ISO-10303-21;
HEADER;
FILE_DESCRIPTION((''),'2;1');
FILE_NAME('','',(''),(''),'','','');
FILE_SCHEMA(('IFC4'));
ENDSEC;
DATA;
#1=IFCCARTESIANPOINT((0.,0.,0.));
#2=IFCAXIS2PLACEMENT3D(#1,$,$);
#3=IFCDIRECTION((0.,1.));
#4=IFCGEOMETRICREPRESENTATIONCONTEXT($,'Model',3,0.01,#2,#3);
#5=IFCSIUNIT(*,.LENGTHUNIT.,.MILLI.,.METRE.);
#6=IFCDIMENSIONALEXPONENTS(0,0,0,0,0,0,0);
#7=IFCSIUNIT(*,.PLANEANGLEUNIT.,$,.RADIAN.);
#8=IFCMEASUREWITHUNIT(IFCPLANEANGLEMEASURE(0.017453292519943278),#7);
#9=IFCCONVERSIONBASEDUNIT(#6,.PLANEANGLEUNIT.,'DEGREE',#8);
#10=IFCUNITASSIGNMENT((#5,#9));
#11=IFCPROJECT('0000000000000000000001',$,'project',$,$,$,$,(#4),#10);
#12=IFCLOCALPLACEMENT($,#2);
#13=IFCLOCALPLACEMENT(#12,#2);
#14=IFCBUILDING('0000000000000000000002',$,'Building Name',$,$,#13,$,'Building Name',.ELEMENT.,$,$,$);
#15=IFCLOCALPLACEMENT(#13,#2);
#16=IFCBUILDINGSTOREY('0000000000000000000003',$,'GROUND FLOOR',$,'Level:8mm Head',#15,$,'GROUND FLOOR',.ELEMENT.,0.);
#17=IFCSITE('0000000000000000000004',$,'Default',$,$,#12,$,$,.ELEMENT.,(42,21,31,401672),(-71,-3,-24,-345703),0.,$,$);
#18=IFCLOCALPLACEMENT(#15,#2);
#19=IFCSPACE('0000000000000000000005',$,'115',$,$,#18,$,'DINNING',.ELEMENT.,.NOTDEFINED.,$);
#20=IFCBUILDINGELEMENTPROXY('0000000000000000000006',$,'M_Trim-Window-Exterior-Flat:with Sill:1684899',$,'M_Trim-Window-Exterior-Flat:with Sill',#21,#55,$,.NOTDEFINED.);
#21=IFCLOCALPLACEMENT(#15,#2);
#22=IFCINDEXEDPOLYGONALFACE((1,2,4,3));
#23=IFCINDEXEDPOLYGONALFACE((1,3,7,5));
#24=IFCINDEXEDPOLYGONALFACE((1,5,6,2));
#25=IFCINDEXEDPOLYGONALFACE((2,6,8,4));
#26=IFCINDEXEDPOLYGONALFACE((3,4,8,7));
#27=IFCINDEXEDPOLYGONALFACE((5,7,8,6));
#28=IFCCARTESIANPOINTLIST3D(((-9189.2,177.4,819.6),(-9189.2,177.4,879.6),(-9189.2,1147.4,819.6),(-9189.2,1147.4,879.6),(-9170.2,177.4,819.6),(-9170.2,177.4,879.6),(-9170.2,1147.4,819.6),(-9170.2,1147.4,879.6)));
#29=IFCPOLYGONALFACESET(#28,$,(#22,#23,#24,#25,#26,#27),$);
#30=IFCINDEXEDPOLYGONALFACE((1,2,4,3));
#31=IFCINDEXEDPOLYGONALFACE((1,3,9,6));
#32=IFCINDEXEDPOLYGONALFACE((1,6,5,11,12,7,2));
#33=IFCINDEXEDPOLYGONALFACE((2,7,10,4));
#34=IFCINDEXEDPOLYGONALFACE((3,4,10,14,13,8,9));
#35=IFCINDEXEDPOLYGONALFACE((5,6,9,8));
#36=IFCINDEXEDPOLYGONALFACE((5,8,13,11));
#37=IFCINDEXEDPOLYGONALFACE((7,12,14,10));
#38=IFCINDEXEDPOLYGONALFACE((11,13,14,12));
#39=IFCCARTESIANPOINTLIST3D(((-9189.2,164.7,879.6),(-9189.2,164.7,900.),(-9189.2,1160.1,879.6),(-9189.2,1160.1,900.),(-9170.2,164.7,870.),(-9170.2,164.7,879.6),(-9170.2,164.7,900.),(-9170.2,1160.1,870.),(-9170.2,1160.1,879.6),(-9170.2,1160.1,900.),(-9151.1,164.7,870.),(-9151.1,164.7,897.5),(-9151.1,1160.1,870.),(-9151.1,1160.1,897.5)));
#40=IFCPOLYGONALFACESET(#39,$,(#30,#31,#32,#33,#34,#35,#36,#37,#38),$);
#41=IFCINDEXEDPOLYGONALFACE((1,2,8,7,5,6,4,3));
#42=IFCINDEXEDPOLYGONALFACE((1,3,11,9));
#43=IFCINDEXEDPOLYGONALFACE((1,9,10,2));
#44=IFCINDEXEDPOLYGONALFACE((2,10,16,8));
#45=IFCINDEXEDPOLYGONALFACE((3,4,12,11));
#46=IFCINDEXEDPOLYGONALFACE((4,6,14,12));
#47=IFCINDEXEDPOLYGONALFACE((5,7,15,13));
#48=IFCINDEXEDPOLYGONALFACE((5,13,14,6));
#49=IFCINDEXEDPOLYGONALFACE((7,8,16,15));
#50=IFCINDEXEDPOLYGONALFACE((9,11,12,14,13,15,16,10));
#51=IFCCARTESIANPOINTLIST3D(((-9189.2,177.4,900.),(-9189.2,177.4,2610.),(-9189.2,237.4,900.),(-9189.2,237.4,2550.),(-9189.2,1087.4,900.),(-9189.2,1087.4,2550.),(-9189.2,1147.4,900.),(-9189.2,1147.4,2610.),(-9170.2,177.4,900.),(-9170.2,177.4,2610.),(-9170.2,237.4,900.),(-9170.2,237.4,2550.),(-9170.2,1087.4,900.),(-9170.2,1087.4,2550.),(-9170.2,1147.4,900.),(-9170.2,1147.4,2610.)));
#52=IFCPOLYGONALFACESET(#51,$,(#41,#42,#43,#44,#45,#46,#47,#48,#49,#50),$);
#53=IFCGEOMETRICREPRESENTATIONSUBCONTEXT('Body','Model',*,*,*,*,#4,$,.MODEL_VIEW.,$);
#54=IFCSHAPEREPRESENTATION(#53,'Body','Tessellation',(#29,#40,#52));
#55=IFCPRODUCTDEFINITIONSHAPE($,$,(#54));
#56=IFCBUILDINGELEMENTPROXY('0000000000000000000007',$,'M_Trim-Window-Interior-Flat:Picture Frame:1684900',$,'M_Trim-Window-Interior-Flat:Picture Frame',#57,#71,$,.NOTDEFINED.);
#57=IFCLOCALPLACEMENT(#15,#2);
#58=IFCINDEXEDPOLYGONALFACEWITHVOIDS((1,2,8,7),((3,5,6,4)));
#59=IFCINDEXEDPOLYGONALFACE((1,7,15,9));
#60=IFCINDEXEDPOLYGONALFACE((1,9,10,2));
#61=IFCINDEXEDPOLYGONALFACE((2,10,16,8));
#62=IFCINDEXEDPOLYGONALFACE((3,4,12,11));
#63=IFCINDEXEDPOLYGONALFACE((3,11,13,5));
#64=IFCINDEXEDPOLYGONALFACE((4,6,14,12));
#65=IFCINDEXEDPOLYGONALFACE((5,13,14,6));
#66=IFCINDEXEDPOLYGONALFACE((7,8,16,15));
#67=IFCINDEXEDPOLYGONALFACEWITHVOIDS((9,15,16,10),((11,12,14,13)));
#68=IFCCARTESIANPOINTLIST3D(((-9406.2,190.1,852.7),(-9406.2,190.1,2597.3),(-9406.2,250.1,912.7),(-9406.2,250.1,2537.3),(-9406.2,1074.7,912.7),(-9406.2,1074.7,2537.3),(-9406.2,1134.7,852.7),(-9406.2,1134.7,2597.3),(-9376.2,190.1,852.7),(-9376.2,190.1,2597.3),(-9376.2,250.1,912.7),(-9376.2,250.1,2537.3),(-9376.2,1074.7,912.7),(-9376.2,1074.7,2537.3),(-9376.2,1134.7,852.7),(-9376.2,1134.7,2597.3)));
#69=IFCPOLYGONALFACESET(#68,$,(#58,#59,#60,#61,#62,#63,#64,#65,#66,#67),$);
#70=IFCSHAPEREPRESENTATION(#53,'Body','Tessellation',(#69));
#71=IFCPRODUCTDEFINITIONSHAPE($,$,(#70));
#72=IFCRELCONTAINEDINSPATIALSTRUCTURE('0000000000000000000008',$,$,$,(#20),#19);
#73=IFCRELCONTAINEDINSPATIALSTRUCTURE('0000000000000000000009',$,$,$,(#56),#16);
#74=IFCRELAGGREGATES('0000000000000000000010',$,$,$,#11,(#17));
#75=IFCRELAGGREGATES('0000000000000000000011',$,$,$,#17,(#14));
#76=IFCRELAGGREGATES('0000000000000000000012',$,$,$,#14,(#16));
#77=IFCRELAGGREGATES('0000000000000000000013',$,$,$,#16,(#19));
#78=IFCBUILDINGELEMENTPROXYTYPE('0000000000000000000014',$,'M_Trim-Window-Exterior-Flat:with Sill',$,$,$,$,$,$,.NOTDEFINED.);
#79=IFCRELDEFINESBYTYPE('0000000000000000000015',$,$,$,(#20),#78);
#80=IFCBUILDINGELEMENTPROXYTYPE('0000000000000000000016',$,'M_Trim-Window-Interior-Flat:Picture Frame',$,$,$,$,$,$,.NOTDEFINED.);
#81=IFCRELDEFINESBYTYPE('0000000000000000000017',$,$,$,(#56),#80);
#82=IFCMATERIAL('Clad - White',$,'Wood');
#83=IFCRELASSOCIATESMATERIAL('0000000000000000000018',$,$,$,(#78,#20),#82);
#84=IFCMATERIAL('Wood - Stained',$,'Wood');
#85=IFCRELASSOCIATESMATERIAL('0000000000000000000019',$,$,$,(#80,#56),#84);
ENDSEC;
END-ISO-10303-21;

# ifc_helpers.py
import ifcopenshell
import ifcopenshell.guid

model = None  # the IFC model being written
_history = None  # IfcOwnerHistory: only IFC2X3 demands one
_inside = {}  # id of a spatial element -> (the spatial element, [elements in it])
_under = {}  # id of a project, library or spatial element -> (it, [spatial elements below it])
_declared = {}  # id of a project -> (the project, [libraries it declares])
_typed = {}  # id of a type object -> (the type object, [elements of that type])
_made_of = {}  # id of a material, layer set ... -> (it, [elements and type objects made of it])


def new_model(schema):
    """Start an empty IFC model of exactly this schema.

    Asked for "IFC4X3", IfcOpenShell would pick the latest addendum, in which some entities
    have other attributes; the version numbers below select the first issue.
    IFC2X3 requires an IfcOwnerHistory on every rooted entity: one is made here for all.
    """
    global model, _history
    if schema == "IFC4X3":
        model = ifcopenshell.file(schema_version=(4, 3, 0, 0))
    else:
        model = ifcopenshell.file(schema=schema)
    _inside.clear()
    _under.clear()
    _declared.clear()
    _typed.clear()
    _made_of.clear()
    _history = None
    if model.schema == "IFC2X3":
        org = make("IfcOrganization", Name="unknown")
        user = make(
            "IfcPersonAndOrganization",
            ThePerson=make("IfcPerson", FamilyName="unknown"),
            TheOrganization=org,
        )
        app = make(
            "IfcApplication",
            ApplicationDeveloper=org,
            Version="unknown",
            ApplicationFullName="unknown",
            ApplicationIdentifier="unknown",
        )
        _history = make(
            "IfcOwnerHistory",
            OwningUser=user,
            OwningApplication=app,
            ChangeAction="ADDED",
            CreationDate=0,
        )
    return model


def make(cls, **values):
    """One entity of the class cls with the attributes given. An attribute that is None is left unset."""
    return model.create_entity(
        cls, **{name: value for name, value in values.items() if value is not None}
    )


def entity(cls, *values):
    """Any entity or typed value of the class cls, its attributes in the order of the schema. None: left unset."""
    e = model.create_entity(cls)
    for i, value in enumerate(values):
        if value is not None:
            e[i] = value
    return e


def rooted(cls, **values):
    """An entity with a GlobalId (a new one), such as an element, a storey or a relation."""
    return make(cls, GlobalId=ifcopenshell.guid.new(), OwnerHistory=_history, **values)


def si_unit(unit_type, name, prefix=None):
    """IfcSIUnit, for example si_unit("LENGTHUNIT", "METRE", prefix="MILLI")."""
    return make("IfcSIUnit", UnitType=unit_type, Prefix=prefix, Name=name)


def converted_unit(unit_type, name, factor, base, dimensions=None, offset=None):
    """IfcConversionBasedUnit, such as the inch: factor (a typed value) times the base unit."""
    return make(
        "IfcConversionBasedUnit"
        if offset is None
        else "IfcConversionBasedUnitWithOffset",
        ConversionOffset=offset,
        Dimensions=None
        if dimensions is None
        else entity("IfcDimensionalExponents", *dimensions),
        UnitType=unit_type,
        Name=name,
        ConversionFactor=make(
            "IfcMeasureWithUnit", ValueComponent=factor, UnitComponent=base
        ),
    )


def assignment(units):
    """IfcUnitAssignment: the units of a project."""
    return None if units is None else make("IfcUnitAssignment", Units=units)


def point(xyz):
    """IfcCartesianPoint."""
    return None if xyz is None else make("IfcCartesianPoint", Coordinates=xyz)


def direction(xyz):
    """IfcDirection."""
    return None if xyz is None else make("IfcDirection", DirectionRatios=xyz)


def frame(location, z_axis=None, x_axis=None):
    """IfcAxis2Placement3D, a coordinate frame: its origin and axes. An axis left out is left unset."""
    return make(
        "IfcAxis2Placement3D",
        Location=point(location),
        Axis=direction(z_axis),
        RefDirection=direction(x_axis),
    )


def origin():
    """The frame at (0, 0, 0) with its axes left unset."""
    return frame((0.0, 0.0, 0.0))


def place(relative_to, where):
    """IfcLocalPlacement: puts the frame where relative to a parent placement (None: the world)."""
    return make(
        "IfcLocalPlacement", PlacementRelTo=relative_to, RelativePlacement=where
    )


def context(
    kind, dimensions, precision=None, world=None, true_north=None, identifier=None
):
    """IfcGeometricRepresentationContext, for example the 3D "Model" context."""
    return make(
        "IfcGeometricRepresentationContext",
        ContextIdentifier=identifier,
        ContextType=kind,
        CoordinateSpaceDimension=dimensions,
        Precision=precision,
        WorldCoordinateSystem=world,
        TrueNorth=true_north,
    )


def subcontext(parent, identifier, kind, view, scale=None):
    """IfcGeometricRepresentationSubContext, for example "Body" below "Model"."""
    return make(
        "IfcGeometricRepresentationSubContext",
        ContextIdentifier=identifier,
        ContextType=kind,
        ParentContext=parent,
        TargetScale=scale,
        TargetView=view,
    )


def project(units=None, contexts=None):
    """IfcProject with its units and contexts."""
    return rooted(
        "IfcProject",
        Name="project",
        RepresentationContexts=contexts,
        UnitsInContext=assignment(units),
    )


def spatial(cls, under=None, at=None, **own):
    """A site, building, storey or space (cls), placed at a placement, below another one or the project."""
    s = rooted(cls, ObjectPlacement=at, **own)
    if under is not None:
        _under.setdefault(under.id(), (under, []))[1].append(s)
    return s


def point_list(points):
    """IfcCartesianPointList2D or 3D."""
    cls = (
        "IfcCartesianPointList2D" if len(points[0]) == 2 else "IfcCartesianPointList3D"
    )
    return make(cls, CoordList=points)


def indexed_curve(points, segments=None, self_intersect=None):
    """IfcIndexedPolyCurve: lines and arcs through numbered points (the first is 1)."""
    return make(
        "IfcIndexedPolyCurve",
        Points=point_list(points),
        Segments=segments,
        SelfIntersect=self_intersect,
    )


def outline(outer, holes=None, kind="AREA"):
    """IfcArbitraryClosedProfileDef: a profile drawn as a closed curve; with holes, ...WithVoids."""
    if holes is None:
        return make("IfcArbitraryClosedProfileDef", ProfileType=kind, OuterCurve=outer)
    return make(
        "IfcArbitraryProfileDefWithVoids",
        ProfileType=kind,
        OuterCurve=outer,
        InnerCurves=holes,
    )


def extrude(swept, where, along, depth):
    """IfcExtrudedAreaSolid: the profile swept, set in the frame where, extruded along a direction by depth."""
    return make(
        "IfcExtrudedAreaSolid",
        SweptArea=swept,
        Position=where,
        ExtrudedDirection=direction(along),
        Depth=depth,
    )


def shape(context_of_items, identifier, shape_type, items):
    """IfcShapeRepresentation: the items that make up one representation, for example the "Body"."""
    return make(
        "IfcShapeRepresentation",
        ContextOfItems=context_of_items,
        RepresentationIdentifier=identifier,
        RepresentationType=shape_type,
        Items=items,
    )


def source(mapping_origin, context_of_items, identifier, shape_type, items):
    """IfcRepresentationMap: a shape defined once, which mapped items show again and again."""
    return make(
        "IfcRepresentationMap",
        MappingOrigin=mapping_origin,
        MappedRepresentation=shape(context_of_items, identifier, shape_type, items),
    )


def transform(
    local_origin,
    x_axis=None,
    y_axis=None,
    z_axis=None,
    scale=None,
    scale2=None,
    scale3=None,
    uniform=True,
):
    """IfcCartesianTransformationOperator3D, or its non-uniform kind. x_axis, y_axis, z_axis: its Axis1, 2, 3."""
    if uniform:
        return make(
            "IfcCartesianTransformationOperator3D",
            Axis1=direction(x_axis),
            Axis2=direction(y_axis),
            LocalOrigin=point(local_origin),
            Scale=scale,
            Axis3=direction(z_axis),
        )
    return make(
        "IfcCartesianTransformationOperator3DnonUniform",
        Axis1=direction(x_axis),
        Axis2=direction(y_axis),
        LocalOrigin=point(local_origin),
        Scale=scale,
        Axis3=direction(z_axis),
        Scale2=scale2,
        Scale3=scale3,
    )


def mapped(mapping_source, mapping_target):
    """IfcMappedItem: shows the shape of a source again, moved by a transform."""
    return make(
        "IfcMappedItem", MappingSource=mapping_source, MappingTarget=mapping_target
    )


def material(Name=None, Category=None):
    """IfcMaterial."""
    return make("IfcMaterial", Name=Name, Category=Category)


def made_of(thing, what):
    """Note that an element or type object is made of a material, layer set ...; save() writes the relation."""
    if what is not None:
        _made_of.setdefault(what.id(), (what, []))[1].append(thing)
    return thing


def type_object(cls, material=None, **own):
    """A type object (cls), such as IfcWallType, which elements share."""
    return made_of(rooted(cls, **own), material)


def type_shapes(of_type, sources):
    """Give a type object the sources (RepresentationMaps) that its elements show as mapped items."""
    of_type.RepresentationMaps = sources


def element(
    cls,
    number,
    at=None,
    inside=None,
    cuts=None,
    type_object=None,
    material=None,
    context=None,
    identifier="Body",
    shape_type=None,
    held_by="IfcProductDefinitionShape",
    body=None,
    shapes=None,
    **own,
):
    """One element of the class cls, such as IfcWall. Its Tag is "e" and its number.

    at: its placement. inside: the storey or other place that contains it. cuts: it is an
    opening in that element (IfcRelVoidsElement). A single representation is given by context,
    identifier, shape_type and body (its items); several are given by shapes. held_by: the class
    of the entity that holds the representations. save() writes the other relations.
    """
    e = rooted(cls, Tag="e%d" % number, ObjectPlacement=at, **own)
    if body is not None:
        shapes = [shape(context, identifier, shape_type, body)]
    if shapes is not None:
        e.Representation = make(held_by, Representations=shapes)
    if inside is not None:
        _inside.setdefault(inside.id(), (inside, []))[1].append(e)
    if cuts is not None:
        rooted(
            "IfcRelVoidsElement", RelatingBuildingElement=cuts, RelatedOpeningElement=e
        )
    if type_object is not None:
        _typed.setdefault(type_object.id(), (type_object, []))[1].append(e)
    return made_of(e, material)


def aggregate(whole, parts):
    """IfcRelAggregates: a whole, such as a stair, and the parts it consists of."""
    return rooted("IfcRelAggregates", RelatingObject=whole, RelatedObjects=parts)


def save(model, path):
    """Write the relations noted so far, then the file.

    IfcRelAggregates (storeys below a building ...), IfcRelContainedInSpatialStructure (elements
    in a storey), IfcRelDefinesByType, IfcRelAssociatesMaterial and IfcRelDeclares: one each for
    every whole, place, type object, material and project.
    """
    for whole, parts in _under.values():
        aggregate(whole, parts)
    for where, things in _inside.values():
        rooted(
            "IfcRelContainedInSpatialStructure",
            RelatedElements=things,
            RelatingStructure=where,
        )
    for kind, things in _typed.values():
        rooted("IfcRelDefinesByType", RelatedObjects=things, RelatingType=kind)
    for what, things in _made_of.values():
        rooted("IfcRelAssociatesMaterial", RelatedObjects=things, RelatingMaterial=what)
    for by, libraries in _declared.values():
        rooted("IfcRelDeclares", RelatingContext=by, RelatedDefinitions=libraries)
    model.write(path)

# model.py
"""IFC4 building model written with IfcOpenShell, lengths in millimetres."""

from ifc_helpers import new_model, entity, si_unit, converted_unit, direction, frame, origin, place, context, subcontext, project, spatial, indexed_curve, outline, extrude, source, transform, mapped, material, type_object, type_shapes, element, save


model = new_model("IFC4")

# Units and contexts
model_context = context("Model", 3, precision=0.01, world=origin(), true_north=direction((0.0, 1.0)))
body_context = subcontext(model_context, "Body", "Model", "MODEL_VIEW")
ifc_project = project(units=[si_unit("LENGTHUNIT", "METRE", prefix="MILLI"), converted_unit("PLANEANGLEUNIT", "DEGREE", entity("IfcPlaneAngleMeasure", 0.017453292519943278), si_unit("PLANEANGLEUNIT", "RADIAN"), dimensions=[0, 0, 0, 0, 0, 0, 0])], contexts=[model_context])

# Site, building, storey
site_placement = place(None, origin())
site = spatial("IfcSite", under=ifc_project, at=site_placement, Name="Default", CompositionType="ELEMENT", RefLatitude=(42, 21, 31, 401672), RefLongitude=(-71, -3, -24, -345703), RefElevation=0.0)
building_placement = place(site_placement, origin())
building = spatial("IfcBuilding", under=site, at=building_placement, Name="Building Name", LongName="Building Name", CompositionType="ELEMENT")
storey_placement = place(building_placement, origin())
storey = spatial("IfcBuildingStorey", under=building, at=storey_placement, Name="GROUND FLOOR", ObjectType="Level:8mm Head", LongName="GROUND FLOOR", CompositionType="ELEMENT", Elevation=0.0)

# Shared definitions
ifc_material_1 = material(Name="Wood - Stained", Category="Wood")

# Shared definitions
ifc_material_2 = material(Name="Clad - White", Category="Wood")

# Shared definitions
space_1_placement = place(storey_placement, origin())
space_1 = spatial("IfcSpace", under=storey, at=space_1_placement, Name="115", LongName="DINNING", CompositionType="ELEMENT", PredefinedType="NOTDEFINED")

# Building element proxies
building_element_proxy_type_1 = type_object("IfcBuildingElementProxyType", Name="M_Trim-Window-Exterior-Flat:with Sill", PredefinedType="NOTDEFINED", material=ifc_material_2)
shared_shape_1 = source(origin(), body_context, "Body", "SweptSolid", [
    extrude(outline(indexed_curve([(-485.0, -30.0), (485.0, -30.0), (485.0, 30.0), (-485.0, 30.0), (-485.0, -30.0)], self_intersect=False)), frame((0.0, -1700.4, 0.0), z_axis=(0.0, 0.0, 1.0), x_axis=(-1.0, 0.0, 0.0)), (0.0, 0.0, 1.0), 19.0),
    extrude(outline(indexed_curve([(-19.0, -15.2), (0.0, -15.2), (0.0, -5.7), (19.0, -5.7), (19.0, 14.8), (0.0, 14.8), (-19.0, 12.3), (-19.0, -15.2)], self_intersect=False)), frame((-497.7, -1664.8, 19.0), z_axis=(1.0, 0.0, 0.0), x_axis=(0.0, 0.0, -1.0)), (0.0, 0.0, 1.0), 995.4),
    extrude(outline(indexed_curve([(-870.0, -485.0), (840.0, -485.0), (840.0, -425.0), (-810.0, -425.0), (-810.0, 425.0), (840.0, 425.0), (840.0, 485.0), (-870.0, 485.0), (-870.0, -485.0)], self_intersect=False)), frame((0.0, -810.0, 0.0), z_axis=(0.0, 0.0, 1.0), x_axis=(0.0, -1.0, 0.0)), (0.0, 0.0, 1.0), 19.0),
])
type_shapes(building_element_proxy_type_1, [shared_shape_1])
proxy_1_placement = place(space_1_placement, frame((-9189.2, 662.4, 2550.0), z_axis=(1.0, 0.0, 0.0), x_axis=(0.0, 1.0, 0.0)))
element("IfcBuildingElementProxy", 1, at=proxy_1_placement, inside=space_1, type_object=building_element_proxy_type_1, material=ifc_material_2, Name="M_Trim-Window-Exterior-Flat:with Sill:1684899", ObjectType="M_Trim-Window-Exterior-Flat:with Sill", PredefinedType="NOTDEFINED", context=body_context, shape_type="MappedRepresentation", body=[
    mapped(shared_shape_1, transform((0.0, 0.0, 0.0), scale=1.0)),
])
building_element_proxy_type_2 = type_object("IfcBuildingElementProxyType", Name="M_Trim-Window-Interior-Flat:Picture Frame", PredefinedType="NOTDEFINED", material=ifc_material_1)
shared_shape_2 = source(origin(), body_context, "Body", "SweptSolid", [
    extrude(outline(indexed_curve([(-472.3, -872.3), (472.3, -872.3), (472.3, 872.3), (-472.3, 872.3), (-472.3, -872.3)], self_intersect=False), holes=[indexed_curve([(-412.3, -812.3), (-412.3, 812.3), (412.3, 812.3), (412.3, -812.3), (-412.3, -812.3)], self_intersect=False)]), frame((0.0, -825.0, 0.0), z_axis=(0.0, 0.0, 1.0), x_axis=(-1.0, 0.0, 0.0)), (0.0, 0.0, 1.0), 30.0),
])
type_shapes(building_element_proxy_type_2, [shared_shape_2])
proxy_2_placement = place(storey_placement, frame((-9376.2, 662.4, 2550.0), z_axis=(-1.0, 0.0, 0.0), x_axis=(0.0, -1.0, 0.0)))
element("IfcBuildingElementProxy", 2, at=proxy_2_placement, inside=storey, type_object=building_element_proxy_type_2, material=ifc_material_1, Name="M_Trim-Window-Interior-Flat:Picture Frame:1684900", ObjectType="M_Trim-Window-Interior-Flat:Picture Frame", PredefinedType="NOTDEFINED", context=body_context, shape_type="MappedRepresentation", body=[
    mapped(shared_shape_2, transform((0.0, 0.0, 0.0), scale=1.0)),
])

save(model, "model.ifc")
